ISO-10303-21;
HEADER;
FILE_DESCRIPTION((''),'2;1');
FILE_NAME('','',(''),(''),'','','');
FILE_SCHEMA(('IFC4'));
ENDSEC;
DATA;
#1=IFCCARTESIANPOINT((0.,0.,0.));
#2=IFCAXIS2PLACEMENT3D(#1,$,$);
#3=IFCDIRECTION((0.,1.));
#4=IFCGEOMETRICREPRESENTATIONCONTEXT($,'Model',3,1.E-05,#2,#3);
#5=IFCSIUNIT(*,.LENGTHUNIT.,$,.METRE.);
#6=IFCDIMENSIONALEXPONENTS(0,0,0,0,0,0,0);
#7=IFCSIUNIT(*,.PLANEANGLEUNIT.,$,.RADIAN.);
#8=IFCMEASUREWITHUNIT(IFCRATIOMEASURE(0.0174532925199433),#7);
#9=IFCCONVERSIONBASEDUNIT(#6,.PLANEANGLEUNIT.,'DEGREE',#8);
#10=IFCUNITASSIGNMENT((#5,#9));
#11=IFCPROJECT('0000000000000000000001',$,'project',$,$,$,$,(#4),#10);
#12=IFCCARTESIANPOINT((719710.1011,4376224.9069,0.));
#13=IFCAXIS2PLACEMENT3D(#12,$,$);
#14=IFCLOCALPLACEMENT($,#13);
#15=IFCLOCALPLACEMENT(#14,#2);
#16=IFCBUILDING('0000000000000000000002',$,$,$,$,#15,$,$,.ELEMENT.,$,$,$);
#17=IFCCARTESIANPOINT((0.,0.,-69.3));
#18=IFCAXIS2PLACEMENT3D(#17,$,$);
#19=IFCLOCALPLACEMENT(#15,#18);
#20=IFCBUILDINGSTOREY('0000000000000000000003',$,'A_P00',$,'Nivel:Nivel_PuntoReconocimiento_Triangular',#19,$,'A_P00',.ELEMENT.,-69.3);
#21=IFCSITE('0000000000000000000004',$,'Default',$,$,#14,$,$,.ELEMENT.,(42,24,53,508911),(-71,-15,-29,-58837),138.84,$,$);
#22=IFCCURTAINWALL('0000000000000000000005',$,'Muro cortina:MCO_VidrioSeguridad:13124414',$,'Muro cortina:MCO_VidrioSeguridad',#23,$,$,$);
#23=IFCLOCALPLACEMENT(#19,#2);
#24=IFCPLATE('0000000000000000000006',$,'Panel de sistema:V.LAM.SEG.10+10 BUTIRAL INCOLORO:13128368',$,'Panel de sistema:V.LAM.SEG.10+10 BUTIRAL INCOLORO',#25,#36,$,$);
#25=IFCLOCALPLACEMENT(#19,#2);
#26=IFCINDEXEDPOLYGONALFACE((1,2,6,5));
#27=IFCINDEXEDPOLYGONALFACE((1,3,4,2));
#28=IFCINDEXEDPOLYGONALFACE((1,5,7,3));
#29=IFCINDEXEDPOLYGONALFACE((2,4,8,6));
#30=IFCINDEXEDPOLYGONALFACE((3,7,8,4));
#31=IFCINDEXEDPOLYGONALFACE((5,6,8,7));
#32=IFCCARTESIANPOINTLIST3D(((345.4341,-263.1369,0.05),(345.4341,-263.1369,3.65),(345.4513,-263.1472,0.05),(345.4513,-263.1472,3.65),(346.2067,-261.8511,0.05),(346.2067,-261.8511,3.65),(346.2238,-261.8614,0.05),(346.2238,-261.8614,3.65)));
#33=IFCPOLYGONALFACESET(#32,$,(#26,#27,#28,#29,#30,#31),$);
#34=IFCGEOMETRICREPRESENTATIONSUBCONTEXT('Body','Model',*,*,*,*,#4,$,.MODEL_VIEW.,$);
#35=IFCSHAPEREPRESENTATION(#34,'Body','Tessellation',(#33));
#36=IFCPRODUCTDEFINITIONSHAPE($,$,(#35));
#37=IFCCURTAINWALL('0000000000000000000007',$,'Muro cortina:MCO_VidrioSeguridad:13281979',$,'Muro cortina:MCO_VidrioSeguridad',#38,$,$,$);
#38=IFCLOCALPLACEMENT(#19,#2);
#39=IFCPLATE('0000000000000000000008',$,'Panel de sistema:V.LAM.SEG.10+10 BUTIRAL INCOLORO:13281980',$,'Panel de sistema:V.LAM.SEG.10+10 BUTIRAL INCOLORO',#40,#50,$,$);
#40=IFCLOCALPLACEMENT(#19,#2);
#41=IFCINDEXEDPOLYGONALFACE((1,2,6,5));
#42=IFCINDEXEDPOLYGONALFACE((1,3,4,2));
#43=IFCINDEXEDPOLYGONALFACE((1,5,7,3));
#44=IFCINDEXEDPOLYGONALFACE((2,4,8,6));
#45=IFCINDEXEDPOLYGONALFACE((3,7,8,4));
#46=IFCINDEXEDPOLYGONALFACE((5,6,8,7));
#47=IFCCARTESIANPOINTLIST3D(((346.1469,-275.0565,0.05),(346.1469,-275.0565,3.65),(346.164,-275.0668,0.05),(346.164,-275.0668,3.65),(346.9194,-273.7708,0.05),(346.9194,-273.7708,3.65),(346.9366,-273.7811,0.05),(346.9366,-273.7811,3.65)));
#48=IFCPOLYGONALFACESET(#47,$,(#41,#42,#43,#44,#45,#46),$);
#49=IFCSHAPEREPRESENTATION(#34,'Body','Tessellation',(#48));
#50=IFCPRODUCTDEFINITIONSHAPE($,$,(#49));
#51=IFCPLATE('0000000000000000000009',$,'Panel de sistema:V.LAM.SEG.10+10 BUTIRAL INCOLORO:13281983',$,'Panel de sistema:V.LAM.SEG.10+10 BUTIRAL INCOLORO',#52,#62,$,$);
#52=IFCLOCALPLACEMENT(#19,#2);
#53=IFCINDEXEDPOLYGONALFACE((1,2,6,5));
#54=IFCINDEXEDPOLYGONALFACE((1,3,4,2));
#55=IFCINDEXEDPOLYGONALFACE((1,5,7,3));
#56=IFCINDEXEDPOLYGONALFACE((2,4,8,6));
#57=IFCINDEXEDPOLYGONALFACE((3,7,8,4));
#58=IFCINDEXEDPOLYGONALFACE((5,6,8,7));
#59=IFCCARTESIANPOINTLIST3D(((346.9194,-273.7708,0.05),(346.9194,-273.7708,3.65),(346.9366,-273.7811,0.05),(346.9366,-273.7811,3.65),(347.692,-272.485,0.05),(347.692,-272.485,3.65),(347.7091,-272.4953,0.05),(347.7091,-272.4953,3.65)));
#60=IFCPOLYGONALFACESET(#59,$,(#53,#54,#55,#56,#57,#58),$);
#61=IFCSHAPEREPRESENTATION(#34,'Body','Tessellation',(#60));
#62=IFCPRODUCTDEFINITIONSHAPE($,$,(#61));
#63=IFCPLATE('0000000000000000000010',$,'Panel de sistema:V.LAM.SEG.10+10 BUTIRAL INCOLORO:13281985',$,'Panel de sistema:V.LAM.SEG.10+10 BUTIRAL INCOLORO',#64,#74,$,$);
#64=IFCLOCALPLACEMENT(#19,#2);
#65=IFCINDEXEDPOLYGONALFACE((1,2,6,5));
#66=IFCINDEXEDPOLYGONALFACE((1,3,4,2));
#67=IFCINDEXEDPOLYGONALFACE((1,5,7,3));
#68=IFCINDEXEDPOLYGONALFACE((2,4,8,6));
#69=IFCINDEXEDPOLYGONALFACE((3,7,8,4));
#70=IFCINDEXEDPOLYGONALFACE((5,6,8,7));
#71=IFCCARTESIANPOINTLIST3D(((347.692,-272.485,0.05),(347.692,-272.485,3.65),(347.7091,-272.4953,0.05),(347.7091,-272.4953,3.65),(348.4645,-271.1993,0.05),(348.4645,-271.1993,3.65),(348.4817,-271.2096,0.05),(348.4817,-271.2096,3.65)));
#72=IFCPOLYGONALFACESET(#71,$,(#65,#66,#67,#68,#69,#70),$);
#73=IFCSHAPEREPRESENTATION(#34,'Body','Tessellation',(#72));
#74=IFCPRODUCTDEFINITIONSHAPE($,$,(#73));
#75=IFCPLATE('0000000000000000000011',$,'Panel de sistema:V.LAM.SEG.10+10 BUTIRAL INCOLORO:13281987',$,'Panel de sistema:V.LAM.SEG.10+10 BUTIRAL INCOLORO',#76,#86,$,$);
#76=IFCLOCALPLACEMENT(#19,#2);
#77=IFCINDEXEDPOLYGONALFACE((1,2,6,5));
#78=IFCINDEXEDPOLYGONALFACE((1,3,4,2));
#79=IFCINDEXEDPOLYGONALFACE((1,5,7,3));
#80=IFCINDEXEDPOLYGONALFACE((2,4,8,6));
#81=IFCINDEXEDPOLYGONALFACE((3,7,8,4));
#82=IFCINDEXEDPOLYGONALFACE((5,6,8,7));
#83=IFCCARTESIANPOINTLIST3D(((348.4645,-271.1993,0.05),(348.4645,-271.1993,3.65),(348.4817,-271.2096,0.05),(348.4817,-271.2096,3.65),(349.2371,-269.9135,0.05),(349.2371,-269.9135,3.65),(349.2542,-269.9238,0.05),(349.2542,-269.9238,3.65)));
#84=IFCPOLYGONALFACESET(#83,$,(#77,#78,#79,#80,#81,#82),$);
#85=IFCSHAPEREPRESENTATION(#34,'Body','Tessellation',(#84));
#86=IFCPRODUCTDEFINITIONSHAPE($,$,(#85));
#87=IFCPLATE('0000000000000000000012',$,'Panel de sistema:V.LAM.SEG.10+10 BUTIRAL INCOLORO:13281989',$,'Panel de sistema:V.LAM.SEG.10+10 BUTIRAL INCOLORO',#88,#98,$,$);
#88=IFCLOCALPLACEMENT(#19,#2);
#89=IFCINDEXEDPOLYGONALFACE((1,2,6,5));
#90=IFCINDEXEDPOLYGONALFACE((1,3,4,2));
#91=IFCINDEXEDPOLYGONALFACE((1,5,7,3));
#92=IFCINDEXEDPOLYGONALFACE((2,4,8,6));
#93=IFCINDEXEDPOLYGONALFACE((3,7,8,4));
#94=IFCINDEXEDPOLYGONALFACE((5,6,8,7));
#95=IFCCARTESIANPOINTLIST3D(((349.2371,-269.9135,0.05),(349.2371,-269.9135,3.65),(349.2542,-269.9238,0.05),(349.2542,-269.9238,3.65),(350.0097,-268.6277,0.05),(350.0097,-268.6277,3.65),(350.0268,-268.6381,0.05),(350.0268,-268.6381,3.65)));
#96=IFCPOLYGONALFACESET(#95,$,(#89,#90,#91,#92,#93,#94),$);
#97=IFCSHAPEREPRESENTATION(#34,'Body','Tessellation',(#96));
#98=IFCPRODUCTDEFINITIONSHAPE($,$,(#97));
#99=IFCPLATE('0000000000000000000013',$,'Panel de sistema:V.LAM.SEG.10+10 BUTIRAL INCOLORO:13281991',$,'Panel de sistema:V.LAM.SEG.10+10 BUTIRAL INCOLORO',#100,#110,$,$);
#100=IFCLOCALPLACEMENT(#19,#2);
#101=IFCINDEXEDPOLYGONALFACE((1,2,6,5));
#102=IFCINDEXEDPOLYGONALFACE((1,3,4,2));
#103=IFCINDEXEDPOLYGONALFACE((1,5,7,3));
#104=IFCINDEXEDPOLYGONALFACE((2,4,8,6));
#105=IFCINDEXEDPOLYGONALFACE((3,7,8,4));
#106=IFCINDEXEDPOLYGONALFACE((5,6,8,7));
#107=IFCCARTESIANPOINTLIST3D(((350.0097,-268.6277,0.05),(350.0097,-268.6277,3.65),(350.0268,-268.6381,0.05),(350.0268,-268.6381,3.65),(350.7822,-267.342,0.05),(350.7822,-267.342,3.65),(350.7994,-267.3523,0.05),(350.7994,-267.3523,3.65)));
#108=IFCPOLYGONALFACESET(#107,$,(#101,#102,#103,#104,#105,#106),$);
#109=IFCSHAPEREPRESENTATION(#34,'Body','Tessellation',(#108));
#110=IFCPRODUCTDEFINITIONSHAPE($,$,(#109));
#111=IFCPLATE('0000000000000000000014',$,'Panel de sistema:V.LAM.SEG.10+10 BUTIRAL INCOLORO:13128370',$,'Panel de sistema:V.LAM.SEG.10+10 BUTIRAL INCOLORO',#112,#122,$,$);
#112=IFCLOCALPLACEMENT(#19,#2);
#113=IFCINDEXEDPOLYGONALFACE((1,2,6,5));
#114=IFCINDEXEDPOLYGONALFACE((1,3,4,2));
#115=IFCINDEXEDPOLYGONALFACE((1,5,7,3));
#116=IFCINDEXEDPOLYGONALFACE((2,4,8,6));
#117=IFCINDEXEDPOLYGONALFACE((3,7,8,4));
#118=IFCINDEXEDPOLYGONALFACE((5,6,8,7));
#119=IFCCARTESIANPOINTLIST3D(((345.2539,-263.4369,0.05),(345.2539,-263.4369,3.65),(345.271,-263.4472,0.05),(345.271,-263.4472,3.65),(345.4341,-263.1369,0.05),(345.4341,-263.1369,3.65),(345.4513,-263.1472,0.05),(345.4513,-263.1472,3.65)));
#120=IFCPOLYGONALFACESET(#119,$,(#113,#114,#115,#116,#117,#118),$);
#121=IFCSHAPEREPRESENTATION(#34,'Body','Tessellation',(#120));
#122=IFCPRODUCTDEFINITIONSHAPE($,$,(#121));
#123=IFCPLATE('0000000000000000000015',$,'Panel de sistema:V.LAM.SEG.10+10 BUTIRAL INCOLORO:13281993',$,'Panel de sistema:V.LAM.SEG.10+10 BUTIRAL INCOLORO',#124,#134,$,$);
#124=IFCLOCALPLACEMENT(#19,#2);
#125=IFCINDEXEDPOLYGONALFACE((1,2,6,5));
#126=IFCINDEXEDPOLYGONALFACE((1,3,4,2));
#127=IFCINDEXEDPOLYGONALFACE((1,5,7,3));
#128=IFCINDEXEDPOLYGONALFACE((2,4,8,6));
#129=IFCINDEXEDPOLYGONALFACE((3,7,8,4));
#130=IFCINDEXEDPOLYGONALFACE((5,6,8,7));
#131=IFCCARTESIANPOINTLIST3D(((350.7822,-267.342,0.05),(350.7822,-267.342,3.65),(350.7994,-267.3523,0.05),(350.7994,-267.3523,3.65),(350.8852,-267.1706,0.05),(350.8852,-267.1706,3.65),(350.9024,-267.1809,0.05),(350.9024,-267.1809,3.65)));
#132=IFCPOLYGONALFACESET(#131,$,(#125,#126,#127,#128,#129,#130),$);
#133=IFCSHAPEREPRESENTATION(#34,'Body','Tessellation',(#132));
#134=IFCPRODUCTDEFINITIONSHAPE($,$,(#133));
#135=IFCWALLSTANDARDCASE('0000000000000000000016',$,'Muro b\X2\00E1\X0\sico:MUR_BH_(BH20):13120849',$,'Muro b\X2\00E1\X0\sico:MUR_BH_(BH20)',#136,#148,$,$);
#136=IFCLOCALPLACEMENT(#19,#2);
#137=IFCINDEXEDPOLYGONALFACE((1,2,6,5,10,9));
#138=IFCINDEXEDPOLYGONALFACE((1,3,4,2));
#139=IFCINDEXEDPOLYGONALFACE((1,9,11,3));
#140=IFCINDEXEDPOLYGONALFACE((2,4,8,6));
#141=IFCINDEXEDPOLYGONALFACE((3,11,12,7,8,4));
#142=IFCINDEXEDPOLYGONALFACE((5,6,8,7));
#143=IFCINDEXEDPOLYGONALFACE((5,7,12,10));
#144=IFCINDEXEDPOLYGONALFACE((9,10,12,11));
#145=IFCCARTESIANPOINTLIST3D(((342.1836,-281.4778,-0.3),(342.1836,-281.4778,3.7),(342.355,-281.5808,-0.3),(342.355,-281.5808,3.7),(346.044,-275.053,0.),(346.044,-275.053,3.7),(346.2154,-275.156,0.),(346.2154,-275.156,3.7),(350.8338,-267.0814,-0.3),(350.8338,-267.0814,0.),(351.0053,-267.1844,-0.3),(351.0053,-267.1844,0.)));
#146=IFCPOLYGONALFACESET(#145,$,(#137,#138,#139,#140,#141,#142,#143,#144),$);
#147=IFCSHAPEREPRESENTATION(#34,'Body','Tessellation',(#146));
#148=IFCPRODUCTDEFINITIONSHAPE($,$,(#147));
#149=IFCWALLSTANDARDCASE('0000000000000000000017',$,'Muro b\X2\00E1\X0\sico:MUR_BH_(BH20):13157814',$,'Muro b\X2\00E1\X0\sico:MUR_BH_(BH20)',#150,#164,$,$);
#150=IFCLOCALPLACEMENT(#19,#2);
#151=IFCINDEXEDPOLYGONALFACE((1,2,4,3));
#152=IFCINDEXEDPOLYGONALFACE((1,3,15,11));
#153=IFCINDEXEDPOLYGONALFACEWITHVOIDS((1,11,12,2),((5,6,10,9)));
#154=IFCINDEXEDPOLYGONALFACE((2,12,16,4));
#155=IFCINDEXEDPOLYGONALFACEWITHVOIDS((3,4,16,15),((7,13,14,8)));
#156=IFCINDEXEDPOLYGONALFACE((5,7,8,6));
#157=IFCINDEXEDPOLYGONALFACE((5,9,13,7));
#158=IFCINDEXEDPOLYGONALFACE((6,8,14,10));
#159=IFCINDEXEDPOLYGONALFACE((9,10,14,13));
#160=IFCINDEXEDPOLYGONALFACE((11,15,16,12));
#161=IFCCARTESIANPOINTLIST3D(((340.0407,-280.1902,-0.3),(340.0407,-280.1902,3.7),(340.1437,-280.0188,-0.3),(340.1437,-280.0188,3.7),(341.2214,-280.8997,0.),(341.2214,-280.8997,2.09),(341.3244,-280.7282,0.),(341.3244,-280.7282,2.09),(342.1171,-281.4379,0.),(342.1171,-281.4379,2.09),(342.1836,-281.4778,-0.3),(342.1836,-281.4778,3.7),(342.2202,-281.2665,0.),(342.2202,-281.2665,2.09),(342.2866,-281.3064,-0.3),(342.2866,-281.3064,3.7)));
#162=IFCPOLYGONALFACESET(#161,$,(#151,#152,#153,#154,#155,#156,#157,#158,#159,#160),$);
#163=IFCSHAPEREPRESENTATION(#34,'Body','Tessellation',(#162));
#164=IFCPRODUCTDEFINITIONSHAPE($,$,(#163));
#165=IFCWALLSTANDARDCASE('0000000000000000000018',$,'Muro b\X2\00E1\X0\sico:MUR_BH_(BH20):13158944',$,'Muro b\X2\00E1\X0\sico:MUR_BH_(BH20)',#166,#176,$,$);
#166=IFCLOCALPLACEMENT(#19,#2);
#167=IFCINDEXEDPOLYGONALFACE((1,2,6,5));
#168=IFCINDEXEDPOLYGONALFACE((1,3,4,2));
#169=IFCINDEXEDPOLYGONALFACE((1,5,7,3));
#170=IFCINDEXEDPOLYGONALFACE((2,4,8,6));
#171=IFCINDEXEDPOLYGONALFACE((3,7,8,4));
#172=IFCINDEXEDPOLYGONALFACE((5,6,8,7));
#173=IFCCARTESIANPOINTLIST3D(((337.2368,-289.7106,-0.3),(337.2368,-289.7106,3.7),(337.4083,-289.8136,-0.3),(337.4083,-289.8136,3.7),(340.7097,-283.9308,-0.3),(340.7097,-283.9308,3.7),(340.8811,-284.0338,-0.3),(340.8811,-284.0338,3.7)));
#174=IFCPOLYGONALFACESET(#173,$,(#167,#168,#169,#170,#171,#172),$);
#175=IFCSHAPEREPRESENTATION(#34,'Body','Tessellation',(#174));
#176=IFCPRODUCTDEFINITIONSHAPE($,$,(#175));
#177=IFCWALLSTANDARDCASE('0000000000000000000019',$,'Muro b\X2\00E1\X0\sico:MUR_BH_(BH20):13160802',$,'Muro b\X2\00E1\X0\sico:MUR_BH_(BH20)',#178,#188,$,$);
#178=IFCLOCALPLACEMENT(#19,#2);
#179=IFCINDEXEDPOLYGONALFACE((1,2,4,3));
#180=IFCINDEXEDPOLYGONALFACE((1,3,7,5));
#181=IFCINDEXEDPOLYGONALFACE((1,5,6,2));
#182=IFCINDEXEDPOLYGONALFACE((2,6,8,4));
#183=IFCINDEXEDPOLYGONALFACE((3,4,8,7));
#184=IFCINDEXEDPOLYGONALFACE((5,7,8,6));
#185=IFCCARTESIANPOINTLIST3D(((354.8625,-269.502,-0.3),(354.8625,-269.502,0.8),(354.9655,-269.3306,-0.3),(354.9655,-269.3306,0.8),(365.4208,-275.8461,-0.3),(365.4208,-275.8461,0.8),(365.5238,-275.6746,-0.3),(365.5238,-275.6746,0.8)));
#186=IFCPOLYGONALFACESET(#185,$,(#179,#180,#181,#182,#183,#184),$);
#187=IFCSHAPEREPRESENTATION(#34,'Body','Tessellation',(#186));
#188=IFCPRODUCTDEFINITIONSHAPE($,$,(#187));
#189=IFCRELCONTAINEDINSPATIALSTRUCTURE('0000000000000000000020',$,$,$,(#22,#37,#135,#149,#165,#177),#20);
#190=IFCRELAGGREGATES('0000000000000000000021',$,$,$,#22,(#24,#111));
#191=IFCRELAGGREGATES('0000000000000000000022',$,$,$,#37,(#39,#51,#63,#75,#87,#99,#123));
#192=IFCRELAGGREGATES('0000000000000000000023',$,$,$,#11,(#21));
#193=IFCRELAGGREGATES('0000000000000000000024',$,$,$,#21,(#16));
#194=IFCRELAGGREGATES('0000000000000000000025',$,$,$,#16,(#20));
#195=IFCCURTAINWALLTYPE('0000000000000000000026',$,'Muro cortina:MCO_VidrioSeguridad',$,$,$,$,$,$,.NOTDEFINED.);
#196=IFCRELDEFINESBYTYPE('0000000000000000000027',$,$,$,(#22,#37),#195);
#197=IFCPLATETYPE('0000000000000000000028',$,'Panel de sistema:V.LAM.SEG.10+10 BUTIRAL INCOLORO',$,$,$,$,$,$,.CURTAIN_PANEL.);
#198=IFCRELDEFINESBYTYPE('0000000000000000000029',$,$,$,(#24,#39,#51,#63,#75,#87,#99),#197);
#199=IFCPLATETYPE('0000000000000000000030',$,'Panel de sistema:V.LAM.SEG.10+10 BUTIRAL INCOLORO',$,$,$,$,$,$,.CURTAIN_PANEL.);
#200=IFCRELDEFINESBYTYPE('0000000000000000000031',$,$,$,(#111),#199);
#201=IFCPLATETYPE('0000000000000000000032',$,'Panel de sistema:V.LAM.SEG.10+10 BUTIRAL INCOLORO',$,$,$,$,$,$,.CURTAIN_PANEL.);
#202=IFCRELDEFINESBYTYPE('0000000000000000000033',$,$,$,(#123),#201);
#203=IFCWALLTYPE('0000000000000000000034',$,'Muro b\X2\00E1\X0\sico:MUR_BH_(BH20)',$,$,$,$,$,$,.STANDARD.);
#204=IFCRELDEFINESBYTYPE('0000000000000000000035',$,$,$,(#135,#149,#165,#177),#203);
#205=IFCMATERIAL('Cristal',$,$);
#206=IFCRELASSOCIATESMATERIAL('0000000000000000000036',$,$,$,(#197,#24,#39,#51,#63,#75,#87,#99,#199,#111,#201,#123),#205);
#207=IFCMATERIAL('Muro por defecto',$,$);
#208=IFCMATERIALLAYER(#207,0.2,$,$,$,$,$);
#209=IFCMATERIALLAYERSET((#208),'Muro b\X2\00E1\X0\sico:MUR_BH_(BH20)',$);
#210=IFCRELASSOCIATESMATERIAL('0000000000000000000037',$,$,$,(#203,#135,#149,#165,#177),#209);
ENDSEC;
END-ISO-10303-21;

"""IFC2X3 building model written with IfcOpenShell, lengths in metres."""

from ifc_helpers import new_model, entity, si_unit, converted_unit, direction, frame, frame_2d, origin, origin_2d_with_axis, place, context, subcontext, project, spatial, rectangle, extrude, source, transform, mapped, material, layer, layer_set, layer_usage, type_object, type_shapes, element, aggregate, save


model = new_model("IFC2X3")

# Units and contexts
model_context = context("Model", 3, precision=1e-05, world=origin(), true_north=direction((0.0, 1.0)))
body_context = subcontext(model_context, "Body", "Model", "MODEL_VIEW")
ifc_project = project(units=[si_unit("LENGTHUNIT", "METRE"), converted_unit("PLANEANGLEUNIT", "DEGREE", entity("IfcRatioMeasure", 0.0174532925199433), si_unit("PLANEANGLEUNIT", "RADIAN"), dimensions=[0, 0, 0, 0, 0, 0, 0])], contexts=[model_context])

# Site, building, storey
site_placement = place(None, frame((719710.1011, 4376224.9069, 0.0)))
site = spatial("IfcSite", under=ifc_project, at=site_placement, Name="Default", CompositionType="ELEMENT", RefLatitude=(42, 24, 53, 508911), RefLongitude=(-71, -15, -29, -58837), RefElevation=138.84)
building_placement = place(site_placement, origin())
building = spatial("IfcBuilding", under=site, at=building_placement, CompositionType="ELEMENT")
storey_placement = place(building_placement, frame((0.0, 0.0, -69.3)))
storey = spatial("IfcBuildingStorey", under=building, at=storey_placement, Name="A_P00", ObjectType="Nivel:Nivel_PuntoReconocimiento_Triangular", LongName="A_P00", CompositionType="ELEMENT", Elevation=-69.3)

# Curtain wall, plate
curtain_wall_type = type_object("IfcCurtainWallType", Name="Muro cortina:MCO_VidrioSeguridad", PredefinedType="NOTDEFINED")
curtain_wall_1_placement = place(storey_placement, frame((0.0, 0.0, 69.3)))
curtain_wall_1 = element("IfcCurtainWall", 1, at=curtain_wall_1_placement, inside=storey, type_object=curtain_wall_type, Name="Muro cortina:MCO_VidrioSeguridad:13124414", ObjectType="Muro cortina:MCO_VidrioSeguridad")
ifc_material_1 = material(Name="Cristal")
plate_type_1 = type_object("IfcPlateType", Name="Panel de sistema:V.LAM.SEG.10+10 BUTIRAL INCOLORO", PredefinedType="CURTAIN_PANEL", material=ifc_material_1)
shared_shape_1 = source(origin(), body_context, "Body", "SweptSolid", [
    extrude(rectangle(XDim=0.02, YDim=1.5, at=frame_2d((0.0, 0.0), x_axis=(1.0, 0.0))), frame((0.0, 0.0, 0.0), z_axis=(0.0, 0.0, 1.0), x_axis=(0.0, 1.0, 0.0)), (0.0, 0.0, 1.0), 3.6),
])
type_shapes(plate_type_1, [shared_shape_1])
plate_1_placement = place(curtain_wall_1_placement, frame((345.829, -262.4992, -69.25), z_axis=(0.0, 0.0, 1.0), x_axis=(-0.515038, -0.857167, 0.0)))
plate_1 = element("IfcPlate", 2, at=plate_1_placement, type_object=plate_type_1, material=ifc_material_1, Name="Panel de sistema:V.LAM.SEG.10+10 BUTIRAL INCOLORO:13128368", ObjectType="Panel de sistema:V.LAM.SEG.10+10 BUTIRAL INCOLORO", context=body_context, shape_type="MappedRepresentation", body=[
    mapped(shared_shape_1, transform((0.0, 0.0, 0.0), scale=1.0)),
])

# Curtain wall, plates
curtain_wall_2_placement = place(storey_placement, frame((0.0, 0.0, 69.3)))
curtain_wall_2 = element("IfcCurtainWall", 3, at=curtain_wall_2_placement, inside=storey, type_object=curtain_wall_type, Name="Muro cortina:MCO_VidrioSeguridad:13281979", ObjectType="Muro cortina:MCO_VidrioSeguridad")
plate_2_placement = place(curtain_wall_2_placement, frame((346.5417, -274.4188, -69.25), z_axis=(0.0, 0.0, 1.0), x_axis=(0.515038, 0.857167, 0.0)))
plate_2 = element("IfcPlate", 4, at=plate_2_placement, type_object=plate_type_1, material=ifc_material_1, Name="Panel de sistema:V.LAM.SEG.10+10 BUTIRAL INCOLORO:13281980", ObjectType="Panel de sistema:V.LAM.SEG.10+10 BUTIRAL INCOLORO", context=body_context, shape_type="MappedRepresentation", body=[
    mapped(shared_shape_1, transform((0.0, 0.0, 0.0), scale=1.0)),
])
plate_3_placement = place(curtain_wall_2_placement, frame((347.3143, -273.133, -69.25), z_axis=(0.0, 0.0, 1.0), x_axis=(0.515038, 0.857167, 0.0)))
plate_3 = element("IfcPlate", 5, at=plate_3_placement, type_object=plate_type_1, material=ifc_material_1, Name="Panel de sistema:V.LAM.SEG.10+10 BUTIRAL INCOLORO:13281983", ObjectType="Panel de sistema:V.LAM.SEG.10+10 BUTIRAL INCOLORO", context=body_context, shape_type="MappedRepresentation", body=[
    mapped(shared_shape_1, transform((0.0, 0.0, 0.0), scale=1.0)),
])
plate_4_placement = place(curtain_wall_2_placement, frame((348.0868, -271.8473, -69.25), z_axis=(0.0, 0.0, 1.0), x_axis=(0.515038, 0.857167, 0.0)))
plate_4 = element("IfcPlate", 6, at=plate_4_placement, type_object=plate_type_1, material=ifc_material_1, Name="Panel de sistema:V.LAM.SEG.10+10 BUTIRAL INCOLORO:13281985", ObjectType="Panel de sistema:V.LAM.SEG.10+10 BUTIRAL INCOLORO", context=body_context, shape_type="MappedRepresentation", body=[
    mapped(shared_shape_1, transform((0.0, 0.0, 0.0), scale=1.0)),
])
plate_5_placement = place(curtain_wall_2_placement, frame((348.8594, -270.5615, -69.25), z_axis=(0.0, 0.0, 1.0), x_axis=(0.515038, 0.857167, 0.0)))
plate_5 = element("IfcPlate", 7, at=plate_5_placement, type_object=plate_type_1, material=ifc_material_1, Name="Panel de sistema:V.LAM.SEG.10+10 BUTIRAL INCOLORO:13281987", ObjectType="Panel de sistema:V.LAM.SEG.10+10 BUTIRAL INCOLORO", context=body_context, shape_type="MappedRepresentation", body=[
    mapped(shared_shape_1, transform((0.0, 0.0, 0.0), scale=1.0)),
])
plate_6_placement = place(curtain_wall_2_placement, frame((349.632, -269.2758, -69.25), z_axis=(0.0, 0.0, 1.0), x_axis=(0.515038, 0.857167, 0.0)))
plate_6 = element("IfcPlate", 8, at=plate_6_placement, type_object=plate_type_1, material=ifc_material_1, Name="Panel de sistema:V.LAM.SEG.10+10 BUTIRAL INCOLORO:13281989", ObjectType="Panel de sistema:V.LAM.SEG.10+10 BUTIRAL INCOLORO", context=body_context, shape_type="MappedRepresentation", body=[
    mapped(shared_shape_1, transform((0.0, 0.0, 0.0), scale=1.0)),
])
plate_7_placement = place(curtain_wall_2_placement, frame((350.4045, -267.99, -69.25), z_axis=(0.0, 0.0, 1.0), x_axis=(0.515038, 0.857167, 0.0)))
plate_7 = element("IfcPlate", 9, at=plate_7_placement, type_object=plate_type_1, material=ifc_material_1, Name="Panel de sistema:V.LAM.SEG.10+10 BUTIRAL INCOLORO:13281991", ObjectType="Panel de sistema:V.LAM.SEG.10+10 BUTIRAL INCOLORO", context=body_context, shape_type="MappedRepresentation", body=[
    mapped(shared_shape_1, transform((0.0, 0.0, 0.0), scale=1.0)),
])

# Plates
plate_type_2 = type_object("IfcPlateType", Name="Panel de sistema:V.LAM.SEG.10+10 BUTIRAL INCOLORO", PredefinedType="CURTAIN_PANEL", material=ifc_material_1)
shared_shape_2 = source(origin(), body_context, "Body", "SweptSolid", [
    extrude(rectangle(XDim=0.02, YDim=0.35, at=origin_2d_with_axis()), frame((0.0, 0.0, 0.0), z_axis=(0.0, 0.0, 1.0), x_axis=(0.0, 1.0, 0.0)), (0.0, 0.0, 1.0), 3.6),
])
type_shapes(plate_type_2, [shared_shape_2])
plate_8_placement = place(curtain_wall_1_placement, frame((345.3526, -263.2921, -69.25), z_axis=(0.0, 0.0, 1.0), x_axis=(-0.515038, -0.857167, 0.0)))
plate_8 = element("IfcPlate", 10, at=plate_8_placement, type_object=plate_type_2, material=ifc_material_1, Name="Panel de sistema:V.LAM.SEG.10+10 BUTIRAL INCOLORO:13128370", ObjectType="Panel de sistema:V.LAM.SEG.10+10 BUTIRAL INCOLORO", context=body_context, shape_type="MappedRepresentation", body=[
    mapped(shared_shape_2, transform((0.0, 0.0, 0.0), scale=1.0)),
])
aggregate(curtain_wall_1, [plate_1, plate_8])
plate_type_3 = type_object("IfcPlateType", Name="Panel de sistema:V.LAM.SEG.10+10 BUTIRAL INCOLORO", PredefinedType="CURTAIN_PANEL", material=ifc_material_1)
shared_shape_3 = source(origin(), body_context, "Body", "SweptSolid", [
    extrude(rectangle(XDim=0.02, YDim=0.2, at=origin_2d_with_axis()), frame((0.0, 0.0, 0.0), z_axis=(0.0, 0.0, 1.0), x_axis=(0.0, 1.0, 0.0)), (0.0, 0.0, 1.0), 3.6),
])
type_shapes(plate_type_3, [shared_shape_3])
plate_9_placement = place(curtain_wall_2_placement, frame((350.8423, -267.2614, -69.25), z_axis=(0.0, 0.0, 1.0), x_axis=(0.515038, 0.857167, 0.0)))
plate_9 = element("IfcPlate", 11, at=plate_9_placement, type_object=plate_type_3, material=ifc_material_1, Name="Panel de sistema:V.LAM.SEG.10+10 BUTIRAL INCOLORO:13281993", ObjectType="Panel de sistema:V.LAM.SEG.10+10 BUTIRAL INCOLORO", context=body_context, shape_type="MappedRepresentation", body=[
    mapped(shared_shape_3, transform((0.0, 0.0, 0.0), scale=1.0)),
])
aggregate(curtain_wall_2, [plate_2, plate_3, plate_4, plate_5, plate_6, plate_7, plate_9])

# Walls, openings
ifc_material_2 = material(Name="Muro por defecto")
ifc_layer = layer(ifc_material_2, 0.2)
ifc_layer_set = layer_set([ifc_layer], Name="Muro básico:MUR_BH_(BH20)")
ifc_layer_usage_1 = layer_usage(ifc_layer_set, "AXIS2", "NEGATIVE", 0.1)
wall_type = type_object("IfcWallType", Name="Muro básico:MUR_BH_(BH20)", PredefinedType="STANDARD", material=ifc_layer_set)
wall_1_placement = place(storey_placement, frame((350.9196, -267.1329, -0.3), z_axis=(0.0, 0.0, 1.0), x_axis=(-0.515038, -0.857167, 0.0)))
wall_1 = element("IfcWallStandardCase", 12, at=wall_1_placement, inside=storey, type_object=wall_type, material=ifc_layer_usage_1, Name="Muro básico:MUR_BH_(BH20):13120849", ObjectType="Muro básico:MUR_BH_(BH20)", context=body_context, shape_type="SweptSolid", body=[
    extrude(rectangle(XDim=16.7954, YDim=0.2, at=frame_2d((8.3977, 0.0), x_axis=(-1.0, 0.0))), origin(), (0.0, 0.0, 1.0), 4.0),
])
opening_1_placement = place(wall_1_placement, origin())
element("IfcOpeningElement", 13, at=opening_1_placement, cuts=wall_1, ObjectType="Opening", context=body_context, shape_type="SweptSolid", body=[
    extrude(rectangle(XDim=3.7, YDim=9.3, at=frame_2d((0.0, 0.0), x_axis=(0.0, 1.0))), frame((4.65, -0.2524, 2.15), z_axis=(0.0, 1.0, 0.0), x_axis=(-1.0, 0.0, 0.0)), (0.0, 0.0, 1.0), 0.5048),
])
ifc_layer_usage_2 = layer_usage(ifc_layer_set, "AXIS2", "POSITIVE", -0.1)
wall_2_placement = place(storey_placement, frame((340.0922, -280.1045, -0.3), z_axis=(0.0, 0.0, 1.0), x_axis=(0.857167, -0.515038, 0.0)))
wall_2 = element("IfcWallStandardCase", 14, at=wall_2_placement, inside=storey, type_object=wall_type, material=ifc_layer_usage_2, Name="Muro básico:MUR_BH_(BH20):13157814", ObjectType="Muro básico:MUR_BH_(BH20)", context=body_context, shape_type="SweptSolid", body=[
    extrude(rectangle(XDim=2.5, YDim=0.2, at=frame_2d((1.25, 0.0), x_axis=(-1.0, 0.0))), origin(), (0.0, 0.0, 1.0), 4.0),
])
opening_2_placement = place(wall_2_placement, frame((-435.7804, 64.936, 0.3), z_axis=(0.0, 0.0, 1.0), x_axis=(0.857167, 0.515038, 0.0)))
element("IfcOpeningElement", 15, at=opening_2_placement, cuts=wall_2, ObjectType="Opening", context=body_context, shape_type="SweptSolid", body=[
    extrude(rectangle(XDim=2.09, YDim=1.045, at=frame_2d((0.0, 0.0), x_axis=(1.0, 0.0))), frame((341.6693, -281.1688, 1.045), z_axis=(0.515038, 0.857167, 0.0), x_axis=(0.0, 0.0, -1.0)), (0.0, 0.0, 1.0), 0.2),
])

# Walls
ifc_layer_usage_3 = layer_usage(ifc_layer_set, "AXIS2", "NEGATIVE", 0.1)
wall_3_placement = place(storey_placement, frame((340.7954, -283.9823, -0.3), z_axis=(0.0, 0.0, 1.0), x_axis=(-0.515038, -0.857167, 0.0)))
element("IfcWallStandardCase", 16, at=wall_3_placement, inside=storey, type_object=wall_type, material=ifc_layer_usage_3, Name="Muro básico:MUR_BH_(BH20):13158944", ObjectType="Muro básico:MUR_BH_(BH20)", context=body_context, shape_type="SweptSolid", body=[
    extrude(rectangle(XDim=6.7428, YDim=0.2, at=frame_2d((3.3714, 0.0), x_axis=(-1.0, 0.0))), origin(), (0.0, 0.0, 1.0), 4.0),
])
ifc_layer_usage_4 = layer_usage(ifc_layer_set, "AXIS2", "NEGATIVE", 0.1)
wall_4_placement = place(storey_placement, frame((354.914, -269.4163, -0.3), z_axis=(0.0, 0.0, 1.0), x_axis=(0.857167, -0.515038, 0.0)))
element("IfcWallStandardCase", 17, at=wall_4_placement, inside=storey, type_object=wall_type, material=ifc_layer_usage_4, Name="Muro básico:MUR_BH_(BH20):13160802", ObjectType="Muro básico:MUR_BH_(BH20)", context=body_context, shape_type="SweptSolid", body=[
    extrude(rectangle(XDim=12.3176, YDim=0.2, at=frame_2d((6.1588, 0.0), x_axis=(-1.0, 0.0))), origin(), (0.0, 0.0, 1.0), 1.1),
])

save(model, "model.ifc")
